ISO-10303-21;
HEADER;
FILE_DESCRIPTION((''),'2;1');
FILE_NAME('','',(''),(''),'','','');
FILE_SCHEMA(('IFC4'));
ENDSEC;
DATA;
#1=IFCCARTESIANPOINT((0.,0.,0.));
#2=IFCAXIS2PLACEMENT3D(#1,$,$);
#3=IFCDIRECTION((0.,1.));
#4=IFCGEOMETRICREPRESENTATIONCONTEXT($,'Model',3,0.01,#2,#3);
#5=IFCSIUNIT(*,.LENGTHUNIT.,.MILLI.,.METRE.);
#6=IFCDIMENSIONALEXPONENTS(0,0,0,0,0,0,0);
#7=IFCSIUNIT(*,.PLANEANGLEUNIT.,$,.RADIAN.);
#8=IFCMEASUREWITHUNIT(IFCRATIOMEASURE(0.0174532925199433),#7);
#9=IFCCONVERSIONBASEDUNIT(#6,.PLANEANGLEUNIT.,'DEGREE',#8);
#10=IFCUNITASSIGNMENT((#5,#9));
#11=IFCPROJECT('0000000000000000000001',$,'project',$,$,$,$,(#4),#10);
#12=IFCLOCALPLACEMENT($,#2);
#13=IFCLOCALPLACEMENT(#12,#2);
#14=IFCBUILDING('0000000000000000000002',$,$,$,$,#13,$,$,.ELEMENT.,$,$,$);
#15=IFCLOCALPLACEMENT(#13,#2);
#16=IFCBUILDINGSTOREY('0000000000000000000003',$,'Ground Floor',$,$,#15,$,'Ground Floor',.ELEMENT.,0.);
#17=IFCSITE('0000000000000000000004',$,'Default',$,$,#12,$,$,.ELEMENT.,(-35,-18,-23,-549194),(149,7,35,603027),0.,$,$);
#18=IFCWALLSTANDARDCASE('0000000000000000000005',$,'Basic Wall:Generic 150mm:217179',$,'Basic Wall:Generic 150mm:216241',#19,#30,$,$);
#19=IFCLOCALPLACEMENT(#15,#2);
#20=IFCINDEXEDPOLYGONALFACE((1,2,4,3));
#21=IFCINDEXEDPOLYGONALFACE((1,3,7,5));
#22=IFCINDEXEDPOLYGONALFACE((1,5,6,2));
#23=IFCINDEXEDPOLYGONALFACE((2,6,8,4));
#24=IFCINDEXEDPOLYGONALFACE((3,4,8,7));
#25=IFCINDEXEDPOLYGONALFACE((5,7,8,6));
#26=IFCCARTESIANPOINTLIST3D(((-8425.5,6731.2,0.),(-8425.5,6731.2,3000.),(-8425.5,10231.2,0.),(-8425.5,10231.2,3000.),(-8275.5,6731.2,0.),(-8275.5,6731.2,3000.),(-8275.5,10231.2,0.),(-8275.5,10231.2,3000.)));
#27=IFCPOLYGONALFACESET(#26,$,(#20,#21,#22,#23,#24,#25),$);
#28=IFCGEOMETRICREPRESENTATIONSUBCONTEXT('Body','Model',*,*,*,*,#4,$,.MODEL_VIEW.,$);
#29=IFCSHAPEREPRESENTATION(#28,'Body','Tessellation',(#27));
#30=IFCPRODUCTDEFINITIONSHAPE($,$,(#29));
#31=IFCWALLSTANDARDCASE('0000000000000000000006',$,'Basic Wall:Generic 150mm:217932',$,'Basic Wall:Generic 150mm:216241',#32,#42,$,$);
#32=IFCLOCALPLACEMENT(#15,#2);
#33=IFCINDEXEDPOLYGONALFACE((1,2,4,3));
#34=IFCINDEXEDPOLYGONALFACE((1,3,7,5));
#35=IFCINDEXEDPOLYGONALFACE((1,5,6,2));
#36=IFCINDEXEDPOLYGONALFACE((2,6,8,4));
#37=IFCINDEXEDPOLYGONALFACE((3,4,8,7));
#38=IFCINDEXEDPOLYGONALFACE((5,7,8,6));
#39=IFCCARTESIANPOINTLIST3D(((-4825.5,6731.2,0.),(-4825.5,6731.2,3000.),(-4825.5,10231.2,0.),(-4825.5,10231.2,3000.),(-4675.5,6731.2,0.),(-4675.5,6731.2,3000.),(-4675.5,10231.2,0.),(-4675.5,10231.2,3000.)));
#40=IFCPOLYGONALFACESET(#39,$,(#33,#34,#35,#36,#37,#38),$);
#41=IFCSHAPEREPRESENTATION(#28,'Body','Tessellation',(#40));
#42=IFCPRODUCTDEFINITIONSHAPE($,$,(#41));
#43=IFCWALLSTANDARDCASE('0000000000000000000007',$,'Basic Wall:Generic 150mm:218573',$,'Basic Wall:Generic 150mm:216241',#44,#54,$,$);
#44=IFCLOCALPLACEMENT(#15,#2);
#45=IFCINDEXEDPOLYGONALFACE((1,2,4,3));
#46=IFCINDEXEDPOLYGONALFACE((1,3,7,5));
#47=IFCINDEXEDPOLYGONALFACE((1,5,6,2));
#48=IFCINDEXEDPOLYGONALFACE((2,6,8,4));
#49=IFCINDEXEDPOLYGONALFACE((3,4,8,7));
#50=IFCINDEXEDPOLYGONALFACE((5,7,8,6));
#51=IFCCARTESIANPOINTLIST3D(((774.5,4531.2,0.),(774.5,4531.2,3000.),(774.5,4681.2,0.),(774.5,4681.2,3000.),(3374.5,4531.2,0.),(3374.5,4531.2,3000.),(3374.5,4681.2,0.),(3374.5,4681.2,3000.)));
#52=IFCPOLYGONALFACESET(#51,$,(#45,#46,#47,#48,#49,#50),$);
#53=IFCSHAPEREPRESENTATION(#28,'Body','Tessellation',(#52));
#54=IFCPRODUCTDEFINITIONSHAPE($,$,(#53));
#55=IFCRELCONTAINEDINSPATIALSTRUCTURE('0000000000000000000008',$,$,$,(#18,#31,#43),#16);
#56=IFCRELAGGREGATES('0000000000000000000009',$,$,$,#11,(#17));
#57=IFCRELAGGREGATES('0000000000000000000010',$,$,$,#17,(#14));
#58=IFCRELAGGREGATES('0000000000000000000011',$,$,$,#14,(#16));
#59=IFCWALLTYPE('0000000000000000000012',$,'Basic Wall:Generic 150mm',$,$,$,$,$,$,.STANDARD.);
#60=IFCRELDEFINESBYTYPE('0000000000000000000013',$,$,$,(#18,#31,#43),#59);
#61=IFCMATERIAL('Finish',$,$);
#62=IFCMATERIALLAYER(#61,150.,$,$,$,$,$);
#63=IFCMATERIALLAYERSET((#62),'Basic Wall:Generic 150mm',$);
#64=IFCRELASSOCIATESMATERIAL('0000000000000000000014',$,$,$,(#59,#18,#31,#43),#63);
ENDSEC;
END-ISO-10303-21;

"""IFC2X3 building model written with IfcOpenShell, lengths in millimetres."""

from ifc_helpers import new_model, entity, si_unit, converted_unit, direction, frame, frame_2d, origin, place, context, subcontext, project, spatial, rectangle, extrude, material, layer, layer_set, layer_usage, type_object, element, save


model = new_model("IFC2X3")

# Units and contexts
model_context = context("Model", 3, precision=0.01, world=origin(), true_north=direction((0.0, 1.0)))
body_context = subcontext(model_context, "Body", "Model", "MODEL_VIEW")
ifc_project = project(units=[si_unit("LENGTHUNIT", "METRE", prefix="MILLI"), converted_unit("PLANEANGLEUNIT", "DEGREE", entity("IfcRatioMeasure", 0.0174532925199433), si_unit("PLANEANGLEUNIT", "RADIAN"), dimensions=[0, 0, 0, 0, 0, 0, 0])], contexts=[model_context])

# Site, building, storey
site_placement = place(None, origin())
site = spatial("IfcSite", under=ifc_project, at=site_placement, Name="Default", CompositionType="ELEMENT", RefLatitude=(-35, -18, -23, -549194), RefLongitude=(149, 7, 35, 603027), RefElevation=0.0)
building_placement = place(site_placement, origin())
building = spatial("IfcBuilding", under=site, at=building_placement, CompositionType="ELEMENT")
storey_placement = place(building_placement, origin())
storey = spatial("IfcBuildingStorey", under=building, at=storey_placement, Name="Ground Floor", LongName="Ground Floor", CompositionType="ELEMENT", Elevation=0.0)

# Shared definitions
ifc_material_1 = material(Name="Finish")

# Walls
ifc_layer_1 = layer(ifc_material_1, 150.0)
ifc_layer_set_1 = layer_set([ifc_layer_1], Name="Basic Wall:Generic 150mm")
wall_type_1 = type_object("IfcWallType", Name="Basic Wall:Generic 150mm", PredefinedType="STANDARD", material=ifc_layer_set_1)
ifc_layer_usage_1 = layer_usage(ifc_layer_set_1, "AXIS2", "POSITIVE", -75.0)
wall_1_placement = place(storey_placement, frame((-8350.5, 6731.2, 0.0), z_axis=(0.0, 0.0, 1.0), x_axis=(0.0, 1.0, 0.0)))
element("IfcWallStandardCase", 1, at=wall_1_placement, inside=storey, type_object=wall_type_1, material=ifc_layer_usage_1, Name="Basic Wall:Generic 150mm:217179", ObjectType="Basic Wall:Generic 150mm:216241", context=body_context, shape_type="SweptSolid", body=[
    extrude(rectangle(XDim=3500.0, YDim=150.0, at=frame_2d((1750.0, 0.0), x_axis=(-1.0, 0.0))), origin(), (0.0, 0.0, 1.0), 3000.0),
])
ifc_layer_usage_2 = layer_usage(ifc_layer_set_1, "AXIS2", "NEGATIVE", 75.0)
wall_2_placement = place(storey_placement, frame((-4750.5, 10231.2, 0.0), z_axis=(0.0, 0.0, 1.0), x_axis=(0.0, -1.0, 0.0)))
element("IfcWallStandardCase", 2, at=wall_2_placement, inside=storey, type_object=wall_type_1, material=ifc_layer_usage_2, Name="Basic Wall:Generic 150mm:217932", ObjectType="Basic Wall:Generic 150mm:216241", context=body_context, shape_type="SweptSolid", body=[
    extrude(rectangle(XDim=3500.0, YDim=150.0, at=frame_2d((1750.0, 0.0), x_axis=(-1.0, 0.0))), origin(), (0.0, 0.0, 1.0), 3000.0),
])
ifc_layer_usage_3 = layer_usage(ifc_layer_set_1, "AXIS2", "NEGATIVE", 75.0)
wall_3_placement = place(storey_placement, frame((774.5, 4606.2, 0.0)))
element("IfcWallStandardCase", 3, at=wall_3_placement, inside=storey, type_object=wall_type_1, material=ifc_layer_usage_3, Name="Basic Wall:Generic 150mm:218573", ObjectType="Basic Wall:Generic 150mm:216241", context=body_context, shape_type="SweptSolid", body=[
    extrude(rectangle(XDim=2600.0, YDim=150.0, at=frame_2d((1300.0, 0.0), x_axis=(-1.0, 0.0))), origin(), (0.0, 0.0, 1.0), 3000.0),
])

save(model, "model.ifc")
